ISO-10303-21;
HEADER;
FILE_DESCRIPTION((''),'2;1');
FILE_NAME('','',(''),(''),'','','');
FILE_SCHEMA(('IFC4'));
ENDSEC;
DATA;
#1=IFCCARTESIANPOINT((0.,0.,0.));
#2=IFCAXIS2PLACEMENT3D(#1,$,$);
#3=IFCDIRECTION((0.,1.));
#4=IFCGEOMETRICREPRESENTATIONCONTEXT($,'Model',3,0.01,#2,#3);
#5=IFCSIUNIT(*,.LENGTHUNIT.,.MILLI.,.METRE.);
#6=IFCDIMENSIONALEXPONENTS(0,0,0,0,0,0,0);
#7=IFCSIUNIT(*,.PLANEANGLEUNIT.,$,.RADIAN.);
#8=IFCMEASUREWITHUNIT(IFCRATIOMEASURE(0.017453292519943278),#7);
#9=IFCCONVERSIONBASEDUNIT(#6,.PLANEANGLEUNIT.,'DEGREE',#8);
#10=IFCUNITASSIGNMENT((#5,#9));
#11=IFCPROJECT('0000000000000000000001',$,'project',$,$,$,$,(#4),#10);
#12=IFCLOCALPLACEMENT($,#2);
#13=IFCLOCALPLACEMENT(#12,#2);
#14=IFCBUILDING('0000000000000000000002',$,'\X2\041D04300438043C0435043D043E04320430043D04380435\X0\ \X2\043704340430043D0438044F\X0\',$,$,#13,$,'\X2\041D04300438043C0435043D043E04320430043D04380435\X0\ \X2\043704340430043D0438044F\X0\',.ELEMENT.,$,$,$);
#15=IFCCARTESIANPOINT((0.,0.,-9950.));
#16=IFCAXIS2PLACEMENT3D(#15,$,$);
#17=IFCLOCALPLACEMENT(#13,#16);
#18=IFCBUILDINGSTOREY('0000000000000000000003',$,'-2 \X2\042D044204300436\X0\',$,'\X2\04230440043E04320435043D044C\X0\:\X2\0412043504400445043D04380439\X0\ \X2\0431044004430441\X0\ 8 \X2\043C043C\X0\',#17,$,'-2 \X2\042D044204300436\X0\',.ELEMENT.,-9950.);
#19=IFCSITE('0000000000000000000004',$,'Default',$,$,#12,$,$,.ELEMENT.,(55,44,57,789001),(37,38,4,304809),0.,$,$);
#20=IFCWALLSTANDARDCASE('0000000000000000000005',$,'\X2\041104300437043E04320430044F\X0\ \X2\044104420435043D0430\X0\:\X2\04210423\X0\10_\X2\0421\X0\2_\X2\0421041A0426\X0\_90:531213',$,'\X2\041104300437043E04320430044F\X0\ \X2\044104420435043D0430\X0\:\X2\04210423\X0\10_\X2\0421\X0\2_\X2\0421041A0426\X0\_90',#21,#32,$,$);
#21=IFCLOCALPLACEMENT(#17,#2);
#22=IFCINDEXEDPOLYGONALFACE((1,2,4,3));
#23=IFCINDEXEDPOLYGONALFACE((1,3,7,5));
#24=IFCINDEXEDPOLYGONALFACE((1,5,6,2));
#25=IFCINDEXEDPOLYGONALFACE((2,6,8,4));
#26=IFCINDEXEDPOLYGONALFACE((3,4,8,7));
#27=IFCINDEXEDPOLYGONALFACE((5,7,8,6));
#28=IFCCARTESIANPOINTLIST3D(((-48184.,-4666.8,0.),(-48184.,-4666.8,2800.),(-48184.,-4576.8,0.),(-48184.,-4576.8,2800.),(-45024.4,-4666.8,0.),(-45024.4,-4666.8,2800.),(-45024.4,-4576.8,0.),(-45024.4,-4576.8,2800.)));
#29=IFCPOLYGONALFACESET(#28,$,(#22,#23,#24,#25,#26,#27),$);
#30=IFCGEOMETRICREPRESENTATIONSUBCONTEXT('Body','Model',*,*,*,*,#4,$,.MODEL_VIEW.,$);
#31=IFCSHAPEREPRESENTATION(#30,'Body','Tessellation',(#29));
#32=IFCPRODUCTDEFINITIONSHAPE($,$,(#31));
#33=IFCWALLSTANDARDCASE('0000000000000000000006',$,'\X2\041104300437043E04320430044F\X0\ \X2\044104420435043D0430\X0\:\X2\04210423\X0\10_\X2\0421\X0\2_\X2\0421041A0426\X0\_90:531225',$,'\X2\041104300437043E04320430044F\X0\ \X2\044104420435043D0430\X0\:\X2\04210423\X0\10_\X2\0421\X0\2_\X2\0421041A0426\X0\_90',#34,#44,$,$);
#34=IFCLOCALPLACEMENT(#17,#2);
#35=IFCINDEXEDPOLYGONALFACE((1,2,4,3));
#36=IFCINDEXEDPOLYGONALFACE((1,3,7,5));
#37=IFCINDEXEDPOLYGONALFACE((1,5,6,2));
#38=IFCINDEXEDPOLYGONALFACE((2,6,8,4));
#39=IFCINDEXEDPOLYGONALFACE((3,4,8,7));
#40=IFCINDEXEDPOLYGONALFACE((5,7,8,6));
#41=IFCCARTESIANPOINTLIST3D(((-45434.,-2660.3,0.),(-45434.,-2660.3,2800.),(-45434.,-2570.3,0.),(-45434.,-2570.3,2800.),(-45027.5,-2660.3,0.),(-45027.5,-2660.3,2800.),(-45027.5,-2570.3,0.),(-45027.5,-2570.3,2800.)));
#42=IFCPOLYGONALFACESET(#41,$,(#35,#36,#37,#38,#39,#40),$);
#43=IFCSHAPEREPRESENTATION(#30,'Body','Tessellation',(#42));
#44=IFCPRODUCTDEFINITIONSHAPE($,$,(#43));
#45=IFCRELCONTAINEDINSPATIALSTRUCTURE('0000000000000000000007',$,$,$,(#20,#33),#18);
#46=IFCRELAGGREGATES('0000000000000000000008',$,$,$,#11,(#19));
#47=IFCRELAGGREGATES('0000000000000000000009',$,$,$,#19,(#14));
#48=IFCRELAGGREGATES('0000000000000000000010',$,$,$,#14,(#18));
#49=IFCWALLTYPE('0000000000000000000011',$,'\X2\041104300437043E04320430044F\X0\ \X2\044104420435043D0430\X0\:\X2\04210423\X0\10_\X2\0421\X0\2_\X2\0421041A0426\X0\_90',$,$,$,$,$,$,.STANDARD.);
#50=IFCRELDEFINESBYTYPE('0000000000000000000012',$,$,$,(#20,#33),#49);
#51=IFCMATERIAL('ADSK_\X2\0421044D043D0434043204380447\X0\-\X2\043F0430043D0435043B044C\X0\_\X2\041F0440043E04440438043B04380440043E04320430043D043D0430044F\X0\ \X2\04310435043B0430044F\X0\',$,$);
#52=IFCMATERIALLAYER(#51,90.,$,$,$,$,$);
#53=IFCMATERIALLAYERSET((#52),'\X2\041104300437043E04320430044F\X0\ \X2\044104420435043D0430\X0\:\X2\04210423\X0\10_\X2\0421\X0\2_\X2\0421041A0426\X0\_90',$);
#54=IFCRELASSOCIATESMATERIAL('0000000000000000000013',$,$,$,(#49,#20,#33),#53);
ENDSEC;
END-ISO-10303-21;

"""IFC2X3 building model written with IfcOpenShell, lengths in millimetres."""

from ifc_helpers import new_model, entity, si_unit, converted_unit, direction, frame, frame_2d, origin, place, context, subcontext, project, spatial, rectangle, extrude, material, layer, layer_set, layer_usage, type_object, element, save


model = new_model("IFC2X3")

# Units and contexts
model_context = context("Model", 3, precision=0.01, world=origin(), true_north=direction((0.0, 1.0)))
body_context = subcontext(model_context, "Body", "Model", "MODEL_VIEW")
ifc_project = project(units=[si_unit("LENGTHUNIT", "METRE", prefix="MILLI"), converted_unit("PLANEANGLEUNIT", "DEGREE", entity("IfcRatioMeasure", 0.017453292519943278), si_unit("PLANEANGLEUNIT", "RADIAN"), dimensions=[0, 0, 0, 0, 0, 0, 0])], contexts=[model_context])

# Site, building, storey
site_placement = place(None, origin())
site = spatial("IfcSite", under=ifc_project, at=site_placement, Name="Default", CompositionType="ELEMENT", RefLatitude=(55, 44, 57, 789001), RefLongitude=(37, 38, 4, 304809), RefElevation=0.0)
building_placement = place(site_placement, origin())
building = spatial("IfcBuilding", under=site, at=building_placement, Name="Наименование здания", LongName="Наименование здания", CompositionType="ELEMENT")
storey_placement = place(building_placement, frame((0.0, 0.0, -9950.0)))
storey = spatial("IfcBuildingStorey", under=building, at=storey_placement, Name="-2 Этаж", ObjectType="Уровень:Верхний брус 8 мм", LongName="-2 Этаж", CompositionType="ELEMENT", Elevation=-9950.0)

# Shared definitions
ifc_material_1 = material(Name="ADSK_Сэндвич-панель_Профилированная белая")
ifc_layer_1 = layer(ifc_material_1, 90.0)
ifc_layer_set_1 = layer_set([ifc_layer_1], Name="Базовая стена:СУ10_С2_СКЦ_90")
ifc_layer_usage_1 = layer_usage(ifc_layer_set_1, "AXIS2", "NEGATIVE", 45.0)
wall_type_1 = type_object("IfcWallType", Name="Базовая стена:СУ10_С2_СКЦ_90", PredefinedType="STANDARD", material=ifc_layer_set_1)

# Walls
wall_1_placement = place(storey_placement, frame((-45024.4, -4621.8, 0.0), z_axis=(0.0, 0.0, 1.0), x_axis=(-1.0, 0.0, 0.0)))
element("IfcWallStandardCase", 1, at=wall_1_placement, inside=storey, type_object=wall_type_1, material=ifc_layer_usage_1, Name="Базовая стена:СУ10_С2_СКЦ_90:531213", ObjectType="Базовая стена:СУ10_С2_СКЦ_90", context=body_context, shape_type="SweptSolid", body=[
    extrude(rectangle(XDim=3159.6, YDim=90.0, at=frame_2d((1579.8, 0.0), x_axis=(-1.0, 0.0))), origin(), (0.0, 0.0, 1.0), 2800.0),
])
wall_2_placement = place(storey_placement, frame((-45027.5, -2615.3, 0.0), z_axis=(0.0, 0.0, 1.0), x_axis=(-1.0, 0.0, 0.0)))
element("IfcWallStandardCase", 2, at=wall_2_placement, inside=storey, type_object=wall_type_1, material=ifc_layer_usage_1, Name="Базовая стена:СУ10_С2_СКЦ_90:531225", ObjectType="Базовая стена:СУ10_С2_СКЦ_90", context=body_context, shape_type="SweptSolid", body=[
    extrude(rectangle(XDim=406.5, YDim=90.0, at=frame_2d((203.2, 0.0), x_axis=(-1.0, 0.0))), origin(), (0.0, 0.0, 1.0), 2800.0),
])

save(model, "model.ifc")
